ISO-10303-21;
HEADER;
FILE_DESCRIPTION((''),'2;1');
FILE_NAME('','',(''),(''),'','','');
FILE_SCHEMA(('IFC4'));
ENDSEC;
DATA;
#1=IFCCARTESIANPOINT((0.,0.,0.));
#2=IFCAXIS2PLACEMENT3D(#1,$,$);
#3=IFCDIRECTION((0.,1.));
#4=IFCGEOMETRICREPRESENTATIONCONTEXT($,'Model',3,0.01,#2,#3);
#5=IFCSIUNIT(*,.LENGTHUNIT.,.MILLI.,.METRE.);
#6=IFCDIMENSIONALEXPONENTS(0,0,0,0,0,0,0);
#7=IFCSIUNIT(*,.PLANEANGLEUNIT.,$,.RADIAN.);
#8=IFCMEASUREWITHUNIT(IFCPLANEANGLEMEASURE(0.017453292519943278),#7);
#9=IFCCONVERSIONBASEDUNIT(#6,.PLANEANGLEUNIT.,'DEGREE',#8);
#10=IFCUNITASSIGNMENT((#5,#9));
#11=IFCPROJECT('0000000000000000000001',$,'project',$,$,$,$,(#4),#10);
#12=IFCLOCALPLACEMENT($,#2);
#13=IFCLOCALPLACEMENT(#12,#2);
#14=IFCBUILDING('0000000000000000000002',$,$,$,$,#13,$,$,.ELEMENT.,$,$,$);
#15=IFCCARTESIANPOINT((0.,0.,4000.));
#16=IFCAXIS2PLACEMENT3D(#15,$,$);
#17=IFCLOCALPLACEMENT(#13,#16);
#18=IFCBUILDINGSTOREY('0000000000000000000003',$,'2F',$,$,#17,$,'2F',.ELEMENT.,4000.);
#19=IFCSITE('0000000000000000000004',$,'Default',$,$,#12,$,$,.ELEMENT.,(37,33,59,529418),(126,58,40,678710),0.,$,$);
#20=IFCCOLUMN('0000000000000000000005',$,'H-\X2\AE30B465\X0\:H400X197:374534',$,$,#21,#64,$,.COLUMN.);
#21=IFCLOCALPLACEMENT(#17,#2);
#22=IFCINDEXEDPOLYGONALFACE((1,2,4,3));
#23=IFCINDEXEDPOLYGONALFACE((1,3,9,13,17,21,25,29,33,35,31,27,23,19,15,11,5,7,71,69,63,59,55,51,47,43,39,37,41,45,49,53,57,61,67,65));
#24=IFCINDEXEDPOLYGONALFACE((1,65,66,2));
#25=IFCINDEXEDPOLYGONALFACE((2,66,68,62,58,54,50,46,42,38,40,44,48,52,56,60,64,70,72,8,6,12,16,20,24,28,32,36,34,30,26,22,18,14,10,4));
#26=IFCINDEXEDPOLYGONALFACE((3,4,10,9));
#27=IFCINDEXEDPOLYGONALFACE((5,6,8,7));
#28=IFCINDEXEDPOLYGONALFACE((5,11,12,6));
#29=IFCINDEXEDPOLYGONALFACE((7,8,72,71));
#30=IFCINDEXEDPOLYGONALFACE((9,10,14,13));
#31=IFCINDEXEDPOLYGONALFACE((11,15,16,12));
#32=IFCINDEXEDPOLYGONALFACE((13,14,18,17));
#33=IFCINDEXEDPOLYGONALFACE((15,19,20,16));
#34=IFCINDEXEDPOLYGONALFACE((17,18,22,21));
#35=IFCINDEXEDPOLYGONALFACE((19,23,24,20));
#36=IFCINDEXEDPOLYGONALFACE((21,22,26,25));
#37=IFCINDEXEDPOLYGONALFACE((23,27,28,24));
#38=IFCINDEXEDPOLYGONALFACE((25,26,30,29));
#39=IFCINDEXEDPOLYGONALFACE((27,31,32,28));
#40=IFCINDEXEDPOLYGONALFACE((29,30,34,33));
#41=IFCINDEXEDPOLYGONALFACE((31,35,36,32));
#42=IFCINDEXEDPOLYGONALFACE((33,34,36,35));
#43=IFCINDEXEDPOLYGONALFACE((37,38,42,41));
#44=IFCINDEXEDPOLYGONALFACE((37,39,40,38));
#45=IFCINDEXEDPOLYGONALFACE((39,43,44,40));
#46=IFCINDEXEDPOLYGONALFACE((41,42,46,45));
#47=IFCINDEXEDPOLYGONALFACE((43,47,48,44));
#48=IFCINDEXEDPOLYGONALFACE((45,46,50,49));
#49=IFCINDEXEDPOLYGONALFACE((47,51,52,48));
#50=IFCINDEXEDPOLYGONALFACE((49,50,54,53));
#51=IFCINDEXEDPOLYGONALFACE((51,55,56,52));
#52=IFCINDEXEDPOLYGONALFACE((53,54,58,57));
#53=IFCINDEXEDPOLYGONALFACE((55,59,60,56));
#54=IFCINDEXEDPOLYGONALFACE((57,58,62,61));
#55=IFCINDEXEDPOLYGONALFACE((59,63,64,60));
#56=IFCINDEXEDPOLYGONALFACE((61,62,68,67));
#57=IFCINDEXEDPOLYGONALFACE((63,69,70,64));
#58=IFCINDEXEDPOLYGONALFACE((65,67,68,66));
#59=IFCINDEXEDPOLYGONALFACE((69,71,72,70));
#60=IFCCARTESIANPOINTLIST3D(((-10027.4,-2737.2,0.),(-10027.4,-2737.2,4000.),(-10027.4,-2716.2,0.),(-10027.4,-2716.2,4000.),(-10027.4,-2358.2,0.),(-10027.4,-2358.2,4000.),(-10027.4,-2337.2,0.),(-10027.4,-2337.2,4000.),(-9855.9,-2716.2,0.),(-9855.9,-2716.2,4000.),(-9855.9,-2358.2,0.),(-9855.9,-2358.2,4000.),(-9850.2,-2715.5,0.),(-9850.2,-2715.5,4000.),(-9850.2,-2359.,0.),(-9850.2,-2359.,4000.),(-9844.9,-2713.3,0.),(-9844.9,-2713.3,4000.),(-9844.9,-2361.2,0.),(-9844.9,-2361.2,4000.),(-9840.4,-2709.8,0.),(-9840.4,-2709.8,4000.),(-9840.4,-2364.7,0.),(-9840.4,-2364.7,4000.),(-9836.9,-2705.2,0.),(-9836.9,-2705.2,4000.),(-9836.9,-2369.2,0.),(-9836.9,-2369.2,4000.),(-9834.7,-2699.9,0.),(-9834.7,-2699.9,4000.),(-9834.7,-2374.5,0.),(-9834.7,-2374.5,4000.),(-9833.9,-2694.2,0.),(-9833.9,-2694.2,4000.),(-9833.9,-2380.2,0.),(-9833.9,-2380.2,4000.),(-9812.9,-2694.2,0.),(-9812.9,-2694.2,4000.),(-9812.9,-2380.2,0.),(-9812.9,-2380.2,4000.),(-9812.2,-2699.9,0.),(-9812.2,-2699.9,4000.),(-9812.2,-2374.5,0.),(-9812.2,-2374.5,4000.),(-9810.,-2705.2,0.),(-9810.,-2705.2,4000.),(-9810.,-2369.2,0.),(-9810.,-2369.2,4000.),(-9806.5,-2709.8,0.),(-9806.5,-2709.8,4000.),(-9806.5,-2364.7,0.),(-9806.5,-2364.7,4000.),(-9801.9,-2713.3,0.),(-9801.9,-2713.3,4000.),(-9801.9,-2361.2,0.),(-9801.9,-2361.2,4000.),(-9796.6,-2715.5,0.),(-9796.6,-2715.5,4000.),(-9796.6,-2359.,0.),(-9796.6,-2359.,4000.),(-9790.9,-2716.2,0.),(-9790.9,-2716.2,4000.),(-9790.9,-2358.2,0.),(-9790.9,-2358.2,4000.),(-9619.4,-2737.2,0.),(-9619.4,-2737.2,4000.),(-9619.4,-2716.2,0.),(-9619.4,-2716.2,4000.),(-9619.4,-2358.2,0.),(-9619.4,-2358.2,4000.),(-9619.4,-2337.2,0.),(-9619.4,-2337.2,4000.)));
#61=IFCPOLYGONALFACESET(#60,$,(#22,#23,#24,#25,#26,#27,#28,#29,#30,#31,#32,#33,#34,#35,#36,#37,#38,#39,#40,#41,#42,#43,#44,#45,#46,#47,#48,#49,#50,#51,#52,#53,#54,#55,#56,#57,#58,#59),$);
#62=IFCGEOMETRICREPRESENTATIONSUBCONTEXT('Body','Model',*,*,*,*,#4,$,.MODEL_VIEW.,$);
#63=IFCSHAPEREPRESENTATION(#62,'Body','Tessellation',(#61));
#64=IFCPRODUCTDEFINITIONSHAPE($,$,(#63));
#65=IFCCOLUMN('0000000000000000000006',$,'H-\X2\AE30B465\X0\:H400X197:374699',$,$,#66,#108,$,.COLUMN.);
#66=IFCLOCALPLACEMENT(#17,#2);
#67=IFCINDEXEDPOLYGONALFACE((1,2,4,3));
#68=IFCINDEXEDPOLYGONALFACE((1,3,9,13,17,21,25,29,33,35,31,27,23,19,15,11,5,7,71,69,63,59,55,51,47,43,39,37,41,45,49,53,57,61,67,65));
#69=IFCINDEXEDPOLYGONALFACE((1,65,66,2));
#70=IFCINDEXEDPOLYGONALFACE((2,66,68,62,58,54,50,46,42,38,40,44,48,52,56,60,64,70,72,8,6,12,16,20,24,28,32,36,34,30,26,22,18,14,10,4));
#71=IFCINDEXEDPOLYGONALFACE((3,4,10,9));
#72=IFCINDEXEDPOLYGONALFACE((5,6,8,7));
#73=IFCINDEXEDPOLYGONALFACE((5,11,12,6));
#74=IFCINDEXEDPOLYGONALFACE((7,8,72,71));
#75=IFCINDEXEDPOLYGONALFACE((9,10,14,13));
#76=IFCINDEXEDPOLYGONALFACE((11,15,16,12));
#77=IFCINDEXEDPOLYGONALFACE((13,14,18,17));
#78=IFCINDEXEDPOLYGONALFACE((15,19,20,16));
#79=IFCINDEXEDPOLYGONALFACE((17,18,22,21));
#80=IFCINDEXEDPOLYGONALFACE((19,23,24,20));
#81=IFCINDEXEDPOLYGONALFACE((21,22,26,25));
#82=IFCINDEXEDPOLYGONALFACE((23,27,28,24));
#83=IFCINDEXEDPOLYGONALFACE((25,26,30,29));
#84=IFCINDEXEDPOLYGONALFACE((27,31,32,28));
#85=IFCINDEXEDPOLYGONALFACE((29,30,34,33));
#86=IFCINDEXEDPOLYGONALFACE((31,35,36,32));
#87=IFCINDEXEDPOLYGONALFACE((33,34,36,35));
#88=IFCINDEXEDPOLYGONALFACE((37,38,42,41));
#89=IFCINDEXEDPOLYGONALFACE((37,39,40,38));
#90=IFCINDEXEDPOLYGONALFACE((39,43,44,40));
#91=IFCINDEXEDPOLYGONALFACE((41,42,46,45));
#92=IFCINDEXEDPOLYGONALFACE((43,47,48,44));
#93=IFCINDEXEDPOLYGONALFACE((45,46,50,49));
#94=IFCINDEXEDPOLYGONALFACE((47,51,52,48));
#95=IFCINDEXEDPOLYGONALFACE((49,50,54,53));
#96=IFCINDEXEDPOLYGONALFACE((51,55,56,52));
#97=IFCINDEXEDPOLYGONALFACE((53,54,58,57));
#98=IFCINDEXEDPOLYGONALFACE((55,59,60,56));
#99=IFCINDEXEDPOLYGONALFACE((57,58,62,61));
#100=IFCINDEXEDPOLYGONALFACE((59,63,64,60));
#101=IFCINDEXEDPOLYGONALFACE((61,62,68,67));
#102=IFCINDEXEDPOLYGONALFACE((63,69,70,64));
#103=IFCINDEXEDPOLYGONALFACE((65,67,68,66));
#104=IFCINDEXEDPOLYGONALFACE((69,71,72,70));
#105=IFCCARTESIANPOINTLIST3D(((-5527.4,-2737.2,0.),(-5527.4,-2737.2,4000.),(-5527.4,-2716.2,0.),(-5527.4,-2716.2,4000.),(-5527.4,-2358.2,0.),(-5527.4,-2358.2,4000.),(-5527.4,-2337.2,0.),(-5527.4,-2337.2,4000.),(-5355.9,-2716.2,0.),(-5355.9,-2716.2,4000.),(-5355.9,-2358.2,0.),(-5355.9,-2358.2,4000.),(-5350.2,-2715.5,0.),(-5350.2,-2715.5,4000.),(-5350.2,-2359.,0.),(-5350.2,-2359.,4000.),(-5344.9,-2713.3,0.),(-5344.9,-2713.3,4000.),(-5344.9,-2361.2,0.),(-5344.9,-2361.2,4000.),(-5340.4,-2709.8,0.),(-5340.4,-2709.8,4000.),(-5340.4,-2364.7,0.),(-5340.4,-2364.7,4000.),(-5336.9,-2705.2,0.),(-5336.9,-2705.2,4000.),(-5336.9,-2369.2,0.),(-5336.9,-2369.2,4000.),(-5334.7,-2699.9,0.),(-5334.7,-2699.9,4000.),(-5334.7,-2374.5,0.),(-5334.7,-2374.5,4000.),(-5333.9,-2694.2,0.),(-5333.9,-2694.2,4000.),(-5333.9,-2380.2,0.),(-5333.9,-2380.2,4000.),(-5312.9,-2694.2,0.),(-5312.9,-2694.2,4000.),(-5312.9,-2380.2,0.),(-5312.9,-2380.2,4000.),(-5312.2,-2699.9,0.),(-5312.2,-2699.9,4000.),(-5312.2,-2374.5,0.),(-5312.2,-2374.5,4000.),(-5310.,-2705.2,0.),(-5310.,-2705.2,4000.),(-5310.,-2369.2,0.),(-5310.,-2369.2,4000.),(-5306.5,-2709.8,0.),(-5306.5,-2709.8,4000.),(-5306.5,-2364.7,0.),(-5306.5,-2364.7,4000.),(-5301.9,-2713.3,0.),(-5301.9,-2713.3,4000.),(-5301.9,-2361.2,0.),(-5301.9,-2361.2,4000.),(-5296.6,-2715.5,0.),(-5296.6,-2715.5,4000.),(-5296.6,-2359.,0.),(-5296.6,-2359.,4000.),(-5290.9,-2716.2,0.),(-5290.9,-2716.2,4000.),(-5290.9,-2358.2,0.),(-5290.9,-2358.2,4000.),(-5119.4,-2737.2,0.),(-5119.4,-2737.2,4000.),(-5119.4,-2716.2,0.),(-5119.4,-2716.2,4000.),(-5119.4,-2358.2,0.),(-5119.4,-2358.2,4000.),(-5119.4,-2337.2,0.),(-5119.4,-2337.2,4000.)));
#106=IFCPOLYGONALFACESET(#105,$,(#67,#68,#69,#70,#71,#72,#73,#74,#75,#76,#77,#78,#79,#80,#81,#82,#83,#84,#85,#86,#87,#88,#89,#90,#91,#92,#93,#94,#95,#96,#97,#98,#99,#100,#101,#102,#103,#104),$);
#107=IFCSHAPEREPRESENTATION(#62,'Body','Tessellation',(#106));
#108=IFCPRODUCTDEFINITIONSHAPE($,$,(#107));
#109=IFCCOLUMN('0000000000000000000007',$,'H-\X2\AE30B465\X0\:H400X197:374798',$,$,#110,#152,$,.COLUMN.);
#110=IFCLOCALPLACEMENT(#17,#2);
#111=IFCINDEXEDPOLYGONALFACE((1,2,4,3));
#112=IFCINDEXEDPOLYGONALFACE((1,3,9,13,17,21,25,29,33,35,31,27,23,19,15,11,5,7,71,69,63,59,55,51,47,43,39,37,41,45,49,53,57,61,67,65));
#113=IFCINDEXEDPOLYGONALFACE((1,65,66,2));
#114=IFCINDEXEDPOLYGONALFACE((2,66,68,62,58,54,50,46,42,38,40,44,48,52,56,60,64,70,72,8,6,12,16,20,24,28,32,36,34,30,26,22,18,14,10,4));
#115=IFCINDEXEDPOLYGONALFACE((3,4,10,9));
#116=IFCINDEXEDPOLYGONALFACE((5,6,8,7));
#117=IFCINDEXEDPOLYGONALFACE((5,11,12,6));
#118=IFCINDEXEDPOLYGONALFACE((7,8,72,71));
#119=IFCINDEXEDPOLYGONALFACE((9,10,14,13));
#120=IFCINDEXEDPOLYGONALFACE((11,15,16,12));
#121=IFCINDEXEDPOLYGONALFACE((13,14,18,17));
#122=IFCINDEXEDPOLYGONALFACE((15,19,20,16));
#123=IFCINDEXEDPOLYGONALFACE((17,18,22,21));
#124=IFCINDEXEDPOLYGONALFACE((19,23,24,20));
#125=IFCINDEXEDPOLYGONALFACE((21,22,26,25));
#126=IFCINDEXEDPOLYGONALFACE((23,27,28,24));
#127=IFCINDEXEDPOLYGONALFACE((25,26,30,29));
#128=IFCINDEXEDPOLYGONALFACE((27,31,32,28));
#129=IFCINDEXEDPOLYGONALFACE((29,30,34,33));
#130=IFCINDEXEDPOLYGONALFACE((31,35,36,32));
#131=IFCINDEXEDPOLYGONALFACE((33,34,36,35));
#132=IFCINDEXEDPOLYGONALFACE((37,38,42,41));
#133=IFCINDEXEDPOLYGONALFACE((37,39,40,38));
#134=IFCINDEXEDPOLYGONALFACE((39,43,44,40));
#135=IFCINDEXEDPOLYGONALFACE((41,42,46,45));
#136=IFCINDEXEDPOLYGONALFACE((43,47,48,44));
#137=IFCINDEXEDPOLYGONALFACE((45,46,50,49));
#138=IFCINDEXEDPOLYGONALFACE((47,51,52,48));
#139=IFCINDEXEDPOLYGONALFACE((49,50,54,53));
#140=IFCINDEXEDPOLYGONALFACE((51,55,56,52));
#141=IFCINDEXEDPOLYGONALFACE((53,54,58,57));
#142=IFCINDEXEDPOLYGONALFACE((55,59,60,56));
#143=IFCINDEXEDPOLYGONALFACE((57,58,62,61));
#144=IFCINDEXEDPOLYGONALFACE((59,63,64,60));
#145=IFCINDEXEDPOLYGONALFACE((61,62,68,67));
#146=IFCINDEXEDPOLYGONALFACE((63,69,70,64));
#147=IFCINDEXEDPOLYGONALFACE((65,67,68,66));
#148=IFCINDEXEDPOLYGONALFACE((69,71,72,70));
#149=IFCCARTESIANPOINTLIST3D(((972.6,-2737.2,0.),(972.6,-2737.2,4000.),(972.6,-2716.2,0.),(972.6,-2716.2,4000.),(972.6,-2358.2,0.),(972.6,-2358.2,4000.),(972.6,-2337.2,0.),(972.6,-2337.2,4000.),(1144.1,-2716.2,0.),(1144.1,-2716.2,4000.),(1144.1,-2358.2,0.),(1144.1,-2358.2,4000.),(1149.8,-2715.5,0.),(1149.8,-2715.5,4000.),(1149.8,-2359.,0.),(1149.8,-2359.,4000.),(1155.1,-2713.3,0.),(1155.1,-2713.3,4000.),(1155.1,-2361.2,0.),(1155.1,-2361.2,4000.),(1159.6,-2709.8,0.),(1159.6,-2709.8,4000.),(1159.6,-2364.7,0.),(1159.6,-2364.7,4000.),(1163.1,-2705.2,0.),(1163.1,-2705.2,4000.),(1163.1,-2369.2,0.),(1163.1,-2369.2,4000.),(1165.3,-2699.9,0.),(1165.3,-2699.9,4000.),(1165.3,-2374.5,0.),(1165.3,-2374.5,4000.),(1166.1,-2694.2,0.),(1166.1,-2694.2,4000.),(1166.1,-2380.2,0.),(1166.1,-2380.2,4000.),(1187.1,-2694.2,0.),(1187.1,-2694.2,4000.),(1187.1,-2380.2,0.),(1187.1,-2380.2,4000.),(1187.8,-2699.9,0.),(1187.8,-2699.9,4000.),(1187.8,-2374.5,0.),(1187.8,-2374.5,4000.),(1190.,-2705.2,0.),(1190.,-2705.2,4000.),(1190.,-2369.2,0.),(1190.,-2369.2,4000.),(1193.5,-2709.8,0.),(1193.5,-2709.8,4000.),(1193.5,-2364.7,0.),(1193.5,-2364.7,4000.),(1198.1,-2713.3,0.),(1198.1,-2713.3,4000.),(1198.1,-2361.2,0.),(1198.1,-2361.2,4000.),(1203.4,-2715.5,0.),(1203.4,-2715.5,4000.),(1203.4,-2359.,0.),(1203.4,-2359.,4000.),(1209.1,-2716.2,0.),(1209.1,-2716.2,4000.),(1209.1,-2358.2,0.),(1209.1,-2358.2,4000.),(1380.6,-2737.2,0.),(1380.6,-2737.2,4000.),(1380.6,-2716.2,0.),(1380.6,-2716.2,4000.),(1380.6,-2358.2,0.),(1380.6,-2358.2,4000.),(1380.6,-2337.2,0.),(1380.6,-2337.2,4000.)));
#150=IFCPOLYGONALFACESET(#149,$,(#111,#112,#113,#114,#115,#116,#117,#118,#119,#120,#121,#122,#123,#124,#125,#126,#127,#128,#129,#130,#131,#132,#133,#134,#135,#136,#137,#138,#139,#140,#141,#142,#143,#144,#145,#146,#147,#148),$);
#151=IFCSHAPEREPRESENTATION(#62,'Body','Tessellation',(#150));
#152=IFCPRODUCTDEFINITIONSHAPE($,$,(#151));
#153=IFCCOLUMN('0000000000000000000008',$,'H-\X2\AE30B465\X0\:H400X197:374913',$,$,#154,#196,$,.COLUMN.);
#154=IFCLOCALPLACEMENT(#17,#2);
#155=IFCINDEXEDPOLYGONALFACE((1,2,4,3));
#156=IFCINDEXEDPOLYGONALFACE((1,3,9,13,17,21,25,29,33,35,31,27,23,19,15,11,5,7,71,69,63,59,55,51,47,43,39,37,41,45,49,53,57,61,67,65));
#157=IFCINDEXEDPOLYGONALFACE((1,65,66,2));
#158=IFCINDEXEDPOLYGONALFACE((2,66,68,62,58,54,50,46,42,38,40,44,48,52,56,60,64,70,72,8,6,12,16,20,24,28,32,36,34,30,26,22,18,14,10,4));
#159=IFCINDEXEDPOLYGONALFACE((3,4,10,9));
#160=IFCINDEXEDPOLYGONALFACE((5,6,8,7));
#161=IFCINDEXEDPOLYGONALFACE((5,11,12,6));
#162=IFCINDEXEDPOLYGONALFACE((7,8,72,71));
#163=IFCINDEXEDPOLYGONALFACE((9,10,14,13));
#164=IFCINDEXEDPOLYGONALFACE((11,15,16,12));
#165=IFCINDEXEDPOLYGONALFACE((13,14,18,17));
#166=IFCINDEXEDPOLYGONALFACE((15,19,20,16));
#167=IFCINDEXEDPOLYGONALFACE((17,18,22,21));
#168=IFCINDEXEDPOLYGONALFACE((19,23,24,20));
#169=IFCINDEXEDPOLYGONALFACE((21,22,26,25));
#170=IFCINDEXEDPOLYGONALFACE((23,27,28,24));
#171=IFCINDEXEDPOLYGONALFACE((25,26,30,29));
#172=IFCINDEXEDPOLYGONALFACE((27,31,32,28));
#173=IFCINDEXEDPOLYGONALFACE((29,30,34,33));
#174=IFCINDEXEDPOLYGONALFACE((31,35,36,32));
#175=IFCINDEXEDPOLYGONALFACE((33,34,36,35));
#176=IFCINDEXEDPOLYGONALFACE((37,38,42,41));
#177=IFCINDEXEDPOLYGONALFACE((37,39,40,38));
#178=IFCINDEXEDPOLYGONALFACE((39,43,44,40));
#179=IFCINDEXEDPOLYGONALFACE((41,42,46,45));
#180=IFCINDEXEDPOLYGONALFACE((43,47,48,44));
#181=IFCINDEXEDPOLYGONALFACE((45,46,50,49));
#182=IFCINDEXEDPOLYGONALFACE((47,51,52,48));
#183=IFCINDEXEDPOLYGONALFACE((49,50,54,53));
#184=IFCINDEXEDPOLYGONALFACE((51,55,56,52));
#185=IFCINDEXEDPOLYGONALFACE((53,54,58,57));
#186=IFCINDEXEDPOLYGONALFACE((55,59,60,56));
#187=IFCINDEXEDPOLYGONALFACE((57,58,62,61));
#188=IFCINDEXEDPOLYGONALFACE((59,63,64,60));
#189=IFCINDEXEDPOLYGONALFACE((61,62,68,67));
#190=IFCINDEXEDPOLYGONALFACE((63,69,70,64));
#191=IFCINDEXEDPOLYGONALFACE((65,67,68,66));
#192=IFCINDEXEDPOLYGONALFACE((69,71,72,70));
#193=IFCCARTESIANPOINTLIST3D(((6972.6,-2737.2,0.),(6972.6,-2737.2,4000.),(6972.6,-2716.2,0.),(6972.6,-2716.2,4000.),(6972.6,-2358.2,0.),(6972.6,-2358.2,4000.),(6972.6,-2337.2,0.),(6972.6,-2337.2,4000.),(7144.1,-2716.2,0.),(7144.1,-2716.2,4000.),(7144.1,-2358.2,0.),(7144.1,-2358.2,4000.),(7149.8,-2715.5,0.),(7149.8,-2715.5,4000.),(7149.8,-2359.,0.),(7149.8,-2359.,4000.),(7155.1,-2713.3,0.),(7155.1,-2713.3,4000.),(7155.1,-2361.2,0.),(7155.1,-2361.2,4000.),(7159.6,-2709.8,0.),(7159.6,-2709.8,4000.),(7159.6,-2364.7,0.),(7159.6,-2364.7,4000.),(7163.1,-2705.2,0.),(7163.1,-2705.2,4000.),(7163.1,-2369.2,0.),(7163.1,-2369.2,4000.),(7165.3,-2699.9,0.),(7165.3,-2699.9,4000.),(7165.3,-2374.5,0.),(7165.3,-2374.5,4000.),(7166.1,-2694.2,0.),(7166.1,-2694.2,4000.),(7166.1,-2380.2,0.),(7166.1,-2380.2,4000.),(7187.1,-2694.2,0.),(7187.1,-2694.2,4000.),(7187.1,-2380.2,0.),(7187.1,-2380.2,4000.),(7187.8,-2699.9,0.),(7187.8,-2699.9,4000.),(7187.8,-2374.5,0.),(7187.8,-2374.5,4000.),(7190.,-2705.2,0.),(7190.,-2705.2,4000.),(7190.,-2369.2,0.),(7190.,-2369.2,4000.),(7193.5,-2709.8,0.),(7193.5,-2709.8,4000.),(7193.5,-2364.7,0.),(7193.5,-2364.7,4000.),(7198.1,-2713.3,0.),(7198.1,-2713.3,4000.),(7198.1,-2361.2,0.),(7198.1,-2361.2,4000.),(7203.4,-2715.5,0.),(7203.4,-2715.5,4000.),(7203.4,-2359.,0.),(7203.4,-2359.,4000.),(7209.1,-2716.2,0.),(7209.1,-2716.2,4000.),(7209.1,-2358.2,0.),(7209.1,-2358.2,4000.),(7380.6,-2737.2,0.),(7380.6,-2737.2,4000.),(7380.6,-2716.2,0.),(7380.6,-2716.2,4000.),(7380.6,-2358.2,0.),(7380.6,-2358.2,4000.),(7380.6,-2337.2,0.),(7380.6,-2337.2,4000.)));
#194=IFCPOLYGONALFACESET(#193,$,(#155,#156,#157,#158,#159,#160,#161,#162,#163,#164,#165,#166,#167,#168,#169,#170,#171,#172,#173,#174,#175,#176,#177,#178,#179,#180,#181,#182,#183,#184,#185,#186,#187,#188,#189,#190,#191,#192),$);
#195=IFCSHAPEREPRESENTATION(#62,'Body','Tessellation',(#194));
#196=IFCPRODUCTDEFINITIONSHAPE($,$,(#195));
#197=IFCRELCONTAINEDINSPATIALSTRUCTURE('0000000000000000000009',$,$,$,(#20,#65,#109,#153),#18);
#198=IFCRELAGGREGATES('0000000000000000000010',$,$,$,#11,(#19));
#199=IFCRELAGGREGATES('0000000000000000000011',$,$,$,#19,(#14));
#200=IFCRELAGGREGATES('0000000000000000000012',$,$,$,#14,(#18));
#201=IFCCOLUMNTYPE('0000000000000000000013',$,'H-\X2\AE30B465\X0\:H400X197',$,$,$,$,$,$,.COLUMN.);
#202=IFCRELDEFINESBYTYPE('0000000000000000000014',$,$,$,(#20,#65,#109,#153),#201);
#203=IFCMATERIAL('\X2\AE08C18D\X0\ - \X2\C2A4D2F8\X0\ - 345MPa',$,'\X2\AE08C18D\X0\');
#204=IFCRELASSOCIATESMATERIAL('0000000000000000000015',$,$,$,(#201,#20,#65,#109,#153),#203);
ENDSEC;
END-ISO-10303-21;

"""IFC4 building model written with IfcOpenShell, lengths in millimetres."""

from ifc_helpers import new_model, entity, si_unit, converted_unit, direction, frame, origin, place, context, subcontext, project, spatial, line, arc, indexed_curve, outline, extrude, source, transform, mapped, material, type_object, type_shapes, element, save


model = new_model("IFC4")

# Units and contexts
model_context = context("Model", 3, precision=0.01, world=origin(), true_north=direction((0.0, 1.0)))
body_context = subcontext(model_context, "Body", "Model", "MODEL_VIEW")
ifc_project = project(units=[si_unit("LENGTHUNIT", "METRE", prefix="MILLI"), converted_unit("PLANEANGLEUNIT", "DEGREE", entity("IfcPlaneAngleMeasure", 0.017453292519943278), si_unit("PLANEANGLEUNIT", "RADIAN"), dimensions=[0, 0, 0, 0, 0, 0, 0])], contexts=[model_context])

# Site, building, storey
site_placement = place(None, origin())
site = spatial("IfcSite", under=ifc_project, at=site_placement, Name="Default", CompositionType="ELEMENT", RefLatitude=(37, 33, 59, 529418), RefLongitude=(126, 58, 40, 678710), RefElevation=0.0)
building_placement = place(site_placement, origin())
building = spatial("IfcBuilding", under=site, at=building_placement, CompositionType="ELEMENT")
storey_placement = place(building_placement, frame((0.0, 0.0, 4000.0)))
storey = spatial("IfcBuildingStorey", under=building, at=storey_placement, Name="2F", LongName="2F", CompositionType="ELEMENT", Elevation=4000.0)

# Columns
ifc_material = material(Name="금속 - 스틸 - 345MPa", Category="금속")
column_type = type_object("IfcColumnType", Name="H-기둥:H400X197", PredefinedType="COLUMN", material=ifc_material)
shared_shape_1 = source(origin(), body_context, "Body", "SweptSolid", [
    extrude(outline(indexed_curve([(-204.0, -200.0), (204.0, -200.0), (204.0, -179.0), (32.5, -179.0), (16.9, -172.6), (10.5, -157.0), (10.5, 157.0), (16.9, 172.6), (32.5, 179.0), (204.0, 179.0), (204.0, 200.0), (-204.0, 200.0), (-204.0, 179.0), (-32.5, 179.0), (-16.9, 172.6), (-10.5, 157.0), (-10.5, -157.0), (-16.9, -172.6), (-32.5, -179.0), (-204.0, -179.0)], segments=[line(1, 2, 3, 4), arc(4, 5, 6), line(6, 7), arc(7, 8, 9), line(9, 10, 11, 12, 13, 14), arc(14, 15, 16), line(16, 17), arc(17, 18, 19), line(19, 20, 1)], self_intersect=False)), frame((0.0, 0.0, 4000.0), z_axis=(0.0, 0.0, 1.0), x_axis=(-1.0, 0.0, 0.0)), (0.0, 0.0, 1.0), 4000.0),
])
type_shapes(column_type, [shared_shape_1])
for number, where, name in (
    (1, (-9823.4, -2537.2, -4000.0), "H-기둥:H400X197:374534"),
    (2, (-5323.4, -2537.2, -4000.0), "H-기둥:H400X197:374699"),
    (3, (1176.6, -2537.2, -4000.0), "H-기둥:H400X197:374798"),
    (4, (7176.6, -2537.2, -4000.0), "H-기둥:H400X197:374913"),
):
    element("IfcColumn", number, at=place(storey_placement, frame(where)), inside=storey, type_object=column_type, material=ifc_material, Name=name, PredefinedType="COLUMN", context=body_context, shape_type="MappedRepresentation", body=[
        mapped(shared_shape_1, transform((0.0, 0.0, 0.0), scale=1.0)),
    ])

save(model, "model.ifc")
